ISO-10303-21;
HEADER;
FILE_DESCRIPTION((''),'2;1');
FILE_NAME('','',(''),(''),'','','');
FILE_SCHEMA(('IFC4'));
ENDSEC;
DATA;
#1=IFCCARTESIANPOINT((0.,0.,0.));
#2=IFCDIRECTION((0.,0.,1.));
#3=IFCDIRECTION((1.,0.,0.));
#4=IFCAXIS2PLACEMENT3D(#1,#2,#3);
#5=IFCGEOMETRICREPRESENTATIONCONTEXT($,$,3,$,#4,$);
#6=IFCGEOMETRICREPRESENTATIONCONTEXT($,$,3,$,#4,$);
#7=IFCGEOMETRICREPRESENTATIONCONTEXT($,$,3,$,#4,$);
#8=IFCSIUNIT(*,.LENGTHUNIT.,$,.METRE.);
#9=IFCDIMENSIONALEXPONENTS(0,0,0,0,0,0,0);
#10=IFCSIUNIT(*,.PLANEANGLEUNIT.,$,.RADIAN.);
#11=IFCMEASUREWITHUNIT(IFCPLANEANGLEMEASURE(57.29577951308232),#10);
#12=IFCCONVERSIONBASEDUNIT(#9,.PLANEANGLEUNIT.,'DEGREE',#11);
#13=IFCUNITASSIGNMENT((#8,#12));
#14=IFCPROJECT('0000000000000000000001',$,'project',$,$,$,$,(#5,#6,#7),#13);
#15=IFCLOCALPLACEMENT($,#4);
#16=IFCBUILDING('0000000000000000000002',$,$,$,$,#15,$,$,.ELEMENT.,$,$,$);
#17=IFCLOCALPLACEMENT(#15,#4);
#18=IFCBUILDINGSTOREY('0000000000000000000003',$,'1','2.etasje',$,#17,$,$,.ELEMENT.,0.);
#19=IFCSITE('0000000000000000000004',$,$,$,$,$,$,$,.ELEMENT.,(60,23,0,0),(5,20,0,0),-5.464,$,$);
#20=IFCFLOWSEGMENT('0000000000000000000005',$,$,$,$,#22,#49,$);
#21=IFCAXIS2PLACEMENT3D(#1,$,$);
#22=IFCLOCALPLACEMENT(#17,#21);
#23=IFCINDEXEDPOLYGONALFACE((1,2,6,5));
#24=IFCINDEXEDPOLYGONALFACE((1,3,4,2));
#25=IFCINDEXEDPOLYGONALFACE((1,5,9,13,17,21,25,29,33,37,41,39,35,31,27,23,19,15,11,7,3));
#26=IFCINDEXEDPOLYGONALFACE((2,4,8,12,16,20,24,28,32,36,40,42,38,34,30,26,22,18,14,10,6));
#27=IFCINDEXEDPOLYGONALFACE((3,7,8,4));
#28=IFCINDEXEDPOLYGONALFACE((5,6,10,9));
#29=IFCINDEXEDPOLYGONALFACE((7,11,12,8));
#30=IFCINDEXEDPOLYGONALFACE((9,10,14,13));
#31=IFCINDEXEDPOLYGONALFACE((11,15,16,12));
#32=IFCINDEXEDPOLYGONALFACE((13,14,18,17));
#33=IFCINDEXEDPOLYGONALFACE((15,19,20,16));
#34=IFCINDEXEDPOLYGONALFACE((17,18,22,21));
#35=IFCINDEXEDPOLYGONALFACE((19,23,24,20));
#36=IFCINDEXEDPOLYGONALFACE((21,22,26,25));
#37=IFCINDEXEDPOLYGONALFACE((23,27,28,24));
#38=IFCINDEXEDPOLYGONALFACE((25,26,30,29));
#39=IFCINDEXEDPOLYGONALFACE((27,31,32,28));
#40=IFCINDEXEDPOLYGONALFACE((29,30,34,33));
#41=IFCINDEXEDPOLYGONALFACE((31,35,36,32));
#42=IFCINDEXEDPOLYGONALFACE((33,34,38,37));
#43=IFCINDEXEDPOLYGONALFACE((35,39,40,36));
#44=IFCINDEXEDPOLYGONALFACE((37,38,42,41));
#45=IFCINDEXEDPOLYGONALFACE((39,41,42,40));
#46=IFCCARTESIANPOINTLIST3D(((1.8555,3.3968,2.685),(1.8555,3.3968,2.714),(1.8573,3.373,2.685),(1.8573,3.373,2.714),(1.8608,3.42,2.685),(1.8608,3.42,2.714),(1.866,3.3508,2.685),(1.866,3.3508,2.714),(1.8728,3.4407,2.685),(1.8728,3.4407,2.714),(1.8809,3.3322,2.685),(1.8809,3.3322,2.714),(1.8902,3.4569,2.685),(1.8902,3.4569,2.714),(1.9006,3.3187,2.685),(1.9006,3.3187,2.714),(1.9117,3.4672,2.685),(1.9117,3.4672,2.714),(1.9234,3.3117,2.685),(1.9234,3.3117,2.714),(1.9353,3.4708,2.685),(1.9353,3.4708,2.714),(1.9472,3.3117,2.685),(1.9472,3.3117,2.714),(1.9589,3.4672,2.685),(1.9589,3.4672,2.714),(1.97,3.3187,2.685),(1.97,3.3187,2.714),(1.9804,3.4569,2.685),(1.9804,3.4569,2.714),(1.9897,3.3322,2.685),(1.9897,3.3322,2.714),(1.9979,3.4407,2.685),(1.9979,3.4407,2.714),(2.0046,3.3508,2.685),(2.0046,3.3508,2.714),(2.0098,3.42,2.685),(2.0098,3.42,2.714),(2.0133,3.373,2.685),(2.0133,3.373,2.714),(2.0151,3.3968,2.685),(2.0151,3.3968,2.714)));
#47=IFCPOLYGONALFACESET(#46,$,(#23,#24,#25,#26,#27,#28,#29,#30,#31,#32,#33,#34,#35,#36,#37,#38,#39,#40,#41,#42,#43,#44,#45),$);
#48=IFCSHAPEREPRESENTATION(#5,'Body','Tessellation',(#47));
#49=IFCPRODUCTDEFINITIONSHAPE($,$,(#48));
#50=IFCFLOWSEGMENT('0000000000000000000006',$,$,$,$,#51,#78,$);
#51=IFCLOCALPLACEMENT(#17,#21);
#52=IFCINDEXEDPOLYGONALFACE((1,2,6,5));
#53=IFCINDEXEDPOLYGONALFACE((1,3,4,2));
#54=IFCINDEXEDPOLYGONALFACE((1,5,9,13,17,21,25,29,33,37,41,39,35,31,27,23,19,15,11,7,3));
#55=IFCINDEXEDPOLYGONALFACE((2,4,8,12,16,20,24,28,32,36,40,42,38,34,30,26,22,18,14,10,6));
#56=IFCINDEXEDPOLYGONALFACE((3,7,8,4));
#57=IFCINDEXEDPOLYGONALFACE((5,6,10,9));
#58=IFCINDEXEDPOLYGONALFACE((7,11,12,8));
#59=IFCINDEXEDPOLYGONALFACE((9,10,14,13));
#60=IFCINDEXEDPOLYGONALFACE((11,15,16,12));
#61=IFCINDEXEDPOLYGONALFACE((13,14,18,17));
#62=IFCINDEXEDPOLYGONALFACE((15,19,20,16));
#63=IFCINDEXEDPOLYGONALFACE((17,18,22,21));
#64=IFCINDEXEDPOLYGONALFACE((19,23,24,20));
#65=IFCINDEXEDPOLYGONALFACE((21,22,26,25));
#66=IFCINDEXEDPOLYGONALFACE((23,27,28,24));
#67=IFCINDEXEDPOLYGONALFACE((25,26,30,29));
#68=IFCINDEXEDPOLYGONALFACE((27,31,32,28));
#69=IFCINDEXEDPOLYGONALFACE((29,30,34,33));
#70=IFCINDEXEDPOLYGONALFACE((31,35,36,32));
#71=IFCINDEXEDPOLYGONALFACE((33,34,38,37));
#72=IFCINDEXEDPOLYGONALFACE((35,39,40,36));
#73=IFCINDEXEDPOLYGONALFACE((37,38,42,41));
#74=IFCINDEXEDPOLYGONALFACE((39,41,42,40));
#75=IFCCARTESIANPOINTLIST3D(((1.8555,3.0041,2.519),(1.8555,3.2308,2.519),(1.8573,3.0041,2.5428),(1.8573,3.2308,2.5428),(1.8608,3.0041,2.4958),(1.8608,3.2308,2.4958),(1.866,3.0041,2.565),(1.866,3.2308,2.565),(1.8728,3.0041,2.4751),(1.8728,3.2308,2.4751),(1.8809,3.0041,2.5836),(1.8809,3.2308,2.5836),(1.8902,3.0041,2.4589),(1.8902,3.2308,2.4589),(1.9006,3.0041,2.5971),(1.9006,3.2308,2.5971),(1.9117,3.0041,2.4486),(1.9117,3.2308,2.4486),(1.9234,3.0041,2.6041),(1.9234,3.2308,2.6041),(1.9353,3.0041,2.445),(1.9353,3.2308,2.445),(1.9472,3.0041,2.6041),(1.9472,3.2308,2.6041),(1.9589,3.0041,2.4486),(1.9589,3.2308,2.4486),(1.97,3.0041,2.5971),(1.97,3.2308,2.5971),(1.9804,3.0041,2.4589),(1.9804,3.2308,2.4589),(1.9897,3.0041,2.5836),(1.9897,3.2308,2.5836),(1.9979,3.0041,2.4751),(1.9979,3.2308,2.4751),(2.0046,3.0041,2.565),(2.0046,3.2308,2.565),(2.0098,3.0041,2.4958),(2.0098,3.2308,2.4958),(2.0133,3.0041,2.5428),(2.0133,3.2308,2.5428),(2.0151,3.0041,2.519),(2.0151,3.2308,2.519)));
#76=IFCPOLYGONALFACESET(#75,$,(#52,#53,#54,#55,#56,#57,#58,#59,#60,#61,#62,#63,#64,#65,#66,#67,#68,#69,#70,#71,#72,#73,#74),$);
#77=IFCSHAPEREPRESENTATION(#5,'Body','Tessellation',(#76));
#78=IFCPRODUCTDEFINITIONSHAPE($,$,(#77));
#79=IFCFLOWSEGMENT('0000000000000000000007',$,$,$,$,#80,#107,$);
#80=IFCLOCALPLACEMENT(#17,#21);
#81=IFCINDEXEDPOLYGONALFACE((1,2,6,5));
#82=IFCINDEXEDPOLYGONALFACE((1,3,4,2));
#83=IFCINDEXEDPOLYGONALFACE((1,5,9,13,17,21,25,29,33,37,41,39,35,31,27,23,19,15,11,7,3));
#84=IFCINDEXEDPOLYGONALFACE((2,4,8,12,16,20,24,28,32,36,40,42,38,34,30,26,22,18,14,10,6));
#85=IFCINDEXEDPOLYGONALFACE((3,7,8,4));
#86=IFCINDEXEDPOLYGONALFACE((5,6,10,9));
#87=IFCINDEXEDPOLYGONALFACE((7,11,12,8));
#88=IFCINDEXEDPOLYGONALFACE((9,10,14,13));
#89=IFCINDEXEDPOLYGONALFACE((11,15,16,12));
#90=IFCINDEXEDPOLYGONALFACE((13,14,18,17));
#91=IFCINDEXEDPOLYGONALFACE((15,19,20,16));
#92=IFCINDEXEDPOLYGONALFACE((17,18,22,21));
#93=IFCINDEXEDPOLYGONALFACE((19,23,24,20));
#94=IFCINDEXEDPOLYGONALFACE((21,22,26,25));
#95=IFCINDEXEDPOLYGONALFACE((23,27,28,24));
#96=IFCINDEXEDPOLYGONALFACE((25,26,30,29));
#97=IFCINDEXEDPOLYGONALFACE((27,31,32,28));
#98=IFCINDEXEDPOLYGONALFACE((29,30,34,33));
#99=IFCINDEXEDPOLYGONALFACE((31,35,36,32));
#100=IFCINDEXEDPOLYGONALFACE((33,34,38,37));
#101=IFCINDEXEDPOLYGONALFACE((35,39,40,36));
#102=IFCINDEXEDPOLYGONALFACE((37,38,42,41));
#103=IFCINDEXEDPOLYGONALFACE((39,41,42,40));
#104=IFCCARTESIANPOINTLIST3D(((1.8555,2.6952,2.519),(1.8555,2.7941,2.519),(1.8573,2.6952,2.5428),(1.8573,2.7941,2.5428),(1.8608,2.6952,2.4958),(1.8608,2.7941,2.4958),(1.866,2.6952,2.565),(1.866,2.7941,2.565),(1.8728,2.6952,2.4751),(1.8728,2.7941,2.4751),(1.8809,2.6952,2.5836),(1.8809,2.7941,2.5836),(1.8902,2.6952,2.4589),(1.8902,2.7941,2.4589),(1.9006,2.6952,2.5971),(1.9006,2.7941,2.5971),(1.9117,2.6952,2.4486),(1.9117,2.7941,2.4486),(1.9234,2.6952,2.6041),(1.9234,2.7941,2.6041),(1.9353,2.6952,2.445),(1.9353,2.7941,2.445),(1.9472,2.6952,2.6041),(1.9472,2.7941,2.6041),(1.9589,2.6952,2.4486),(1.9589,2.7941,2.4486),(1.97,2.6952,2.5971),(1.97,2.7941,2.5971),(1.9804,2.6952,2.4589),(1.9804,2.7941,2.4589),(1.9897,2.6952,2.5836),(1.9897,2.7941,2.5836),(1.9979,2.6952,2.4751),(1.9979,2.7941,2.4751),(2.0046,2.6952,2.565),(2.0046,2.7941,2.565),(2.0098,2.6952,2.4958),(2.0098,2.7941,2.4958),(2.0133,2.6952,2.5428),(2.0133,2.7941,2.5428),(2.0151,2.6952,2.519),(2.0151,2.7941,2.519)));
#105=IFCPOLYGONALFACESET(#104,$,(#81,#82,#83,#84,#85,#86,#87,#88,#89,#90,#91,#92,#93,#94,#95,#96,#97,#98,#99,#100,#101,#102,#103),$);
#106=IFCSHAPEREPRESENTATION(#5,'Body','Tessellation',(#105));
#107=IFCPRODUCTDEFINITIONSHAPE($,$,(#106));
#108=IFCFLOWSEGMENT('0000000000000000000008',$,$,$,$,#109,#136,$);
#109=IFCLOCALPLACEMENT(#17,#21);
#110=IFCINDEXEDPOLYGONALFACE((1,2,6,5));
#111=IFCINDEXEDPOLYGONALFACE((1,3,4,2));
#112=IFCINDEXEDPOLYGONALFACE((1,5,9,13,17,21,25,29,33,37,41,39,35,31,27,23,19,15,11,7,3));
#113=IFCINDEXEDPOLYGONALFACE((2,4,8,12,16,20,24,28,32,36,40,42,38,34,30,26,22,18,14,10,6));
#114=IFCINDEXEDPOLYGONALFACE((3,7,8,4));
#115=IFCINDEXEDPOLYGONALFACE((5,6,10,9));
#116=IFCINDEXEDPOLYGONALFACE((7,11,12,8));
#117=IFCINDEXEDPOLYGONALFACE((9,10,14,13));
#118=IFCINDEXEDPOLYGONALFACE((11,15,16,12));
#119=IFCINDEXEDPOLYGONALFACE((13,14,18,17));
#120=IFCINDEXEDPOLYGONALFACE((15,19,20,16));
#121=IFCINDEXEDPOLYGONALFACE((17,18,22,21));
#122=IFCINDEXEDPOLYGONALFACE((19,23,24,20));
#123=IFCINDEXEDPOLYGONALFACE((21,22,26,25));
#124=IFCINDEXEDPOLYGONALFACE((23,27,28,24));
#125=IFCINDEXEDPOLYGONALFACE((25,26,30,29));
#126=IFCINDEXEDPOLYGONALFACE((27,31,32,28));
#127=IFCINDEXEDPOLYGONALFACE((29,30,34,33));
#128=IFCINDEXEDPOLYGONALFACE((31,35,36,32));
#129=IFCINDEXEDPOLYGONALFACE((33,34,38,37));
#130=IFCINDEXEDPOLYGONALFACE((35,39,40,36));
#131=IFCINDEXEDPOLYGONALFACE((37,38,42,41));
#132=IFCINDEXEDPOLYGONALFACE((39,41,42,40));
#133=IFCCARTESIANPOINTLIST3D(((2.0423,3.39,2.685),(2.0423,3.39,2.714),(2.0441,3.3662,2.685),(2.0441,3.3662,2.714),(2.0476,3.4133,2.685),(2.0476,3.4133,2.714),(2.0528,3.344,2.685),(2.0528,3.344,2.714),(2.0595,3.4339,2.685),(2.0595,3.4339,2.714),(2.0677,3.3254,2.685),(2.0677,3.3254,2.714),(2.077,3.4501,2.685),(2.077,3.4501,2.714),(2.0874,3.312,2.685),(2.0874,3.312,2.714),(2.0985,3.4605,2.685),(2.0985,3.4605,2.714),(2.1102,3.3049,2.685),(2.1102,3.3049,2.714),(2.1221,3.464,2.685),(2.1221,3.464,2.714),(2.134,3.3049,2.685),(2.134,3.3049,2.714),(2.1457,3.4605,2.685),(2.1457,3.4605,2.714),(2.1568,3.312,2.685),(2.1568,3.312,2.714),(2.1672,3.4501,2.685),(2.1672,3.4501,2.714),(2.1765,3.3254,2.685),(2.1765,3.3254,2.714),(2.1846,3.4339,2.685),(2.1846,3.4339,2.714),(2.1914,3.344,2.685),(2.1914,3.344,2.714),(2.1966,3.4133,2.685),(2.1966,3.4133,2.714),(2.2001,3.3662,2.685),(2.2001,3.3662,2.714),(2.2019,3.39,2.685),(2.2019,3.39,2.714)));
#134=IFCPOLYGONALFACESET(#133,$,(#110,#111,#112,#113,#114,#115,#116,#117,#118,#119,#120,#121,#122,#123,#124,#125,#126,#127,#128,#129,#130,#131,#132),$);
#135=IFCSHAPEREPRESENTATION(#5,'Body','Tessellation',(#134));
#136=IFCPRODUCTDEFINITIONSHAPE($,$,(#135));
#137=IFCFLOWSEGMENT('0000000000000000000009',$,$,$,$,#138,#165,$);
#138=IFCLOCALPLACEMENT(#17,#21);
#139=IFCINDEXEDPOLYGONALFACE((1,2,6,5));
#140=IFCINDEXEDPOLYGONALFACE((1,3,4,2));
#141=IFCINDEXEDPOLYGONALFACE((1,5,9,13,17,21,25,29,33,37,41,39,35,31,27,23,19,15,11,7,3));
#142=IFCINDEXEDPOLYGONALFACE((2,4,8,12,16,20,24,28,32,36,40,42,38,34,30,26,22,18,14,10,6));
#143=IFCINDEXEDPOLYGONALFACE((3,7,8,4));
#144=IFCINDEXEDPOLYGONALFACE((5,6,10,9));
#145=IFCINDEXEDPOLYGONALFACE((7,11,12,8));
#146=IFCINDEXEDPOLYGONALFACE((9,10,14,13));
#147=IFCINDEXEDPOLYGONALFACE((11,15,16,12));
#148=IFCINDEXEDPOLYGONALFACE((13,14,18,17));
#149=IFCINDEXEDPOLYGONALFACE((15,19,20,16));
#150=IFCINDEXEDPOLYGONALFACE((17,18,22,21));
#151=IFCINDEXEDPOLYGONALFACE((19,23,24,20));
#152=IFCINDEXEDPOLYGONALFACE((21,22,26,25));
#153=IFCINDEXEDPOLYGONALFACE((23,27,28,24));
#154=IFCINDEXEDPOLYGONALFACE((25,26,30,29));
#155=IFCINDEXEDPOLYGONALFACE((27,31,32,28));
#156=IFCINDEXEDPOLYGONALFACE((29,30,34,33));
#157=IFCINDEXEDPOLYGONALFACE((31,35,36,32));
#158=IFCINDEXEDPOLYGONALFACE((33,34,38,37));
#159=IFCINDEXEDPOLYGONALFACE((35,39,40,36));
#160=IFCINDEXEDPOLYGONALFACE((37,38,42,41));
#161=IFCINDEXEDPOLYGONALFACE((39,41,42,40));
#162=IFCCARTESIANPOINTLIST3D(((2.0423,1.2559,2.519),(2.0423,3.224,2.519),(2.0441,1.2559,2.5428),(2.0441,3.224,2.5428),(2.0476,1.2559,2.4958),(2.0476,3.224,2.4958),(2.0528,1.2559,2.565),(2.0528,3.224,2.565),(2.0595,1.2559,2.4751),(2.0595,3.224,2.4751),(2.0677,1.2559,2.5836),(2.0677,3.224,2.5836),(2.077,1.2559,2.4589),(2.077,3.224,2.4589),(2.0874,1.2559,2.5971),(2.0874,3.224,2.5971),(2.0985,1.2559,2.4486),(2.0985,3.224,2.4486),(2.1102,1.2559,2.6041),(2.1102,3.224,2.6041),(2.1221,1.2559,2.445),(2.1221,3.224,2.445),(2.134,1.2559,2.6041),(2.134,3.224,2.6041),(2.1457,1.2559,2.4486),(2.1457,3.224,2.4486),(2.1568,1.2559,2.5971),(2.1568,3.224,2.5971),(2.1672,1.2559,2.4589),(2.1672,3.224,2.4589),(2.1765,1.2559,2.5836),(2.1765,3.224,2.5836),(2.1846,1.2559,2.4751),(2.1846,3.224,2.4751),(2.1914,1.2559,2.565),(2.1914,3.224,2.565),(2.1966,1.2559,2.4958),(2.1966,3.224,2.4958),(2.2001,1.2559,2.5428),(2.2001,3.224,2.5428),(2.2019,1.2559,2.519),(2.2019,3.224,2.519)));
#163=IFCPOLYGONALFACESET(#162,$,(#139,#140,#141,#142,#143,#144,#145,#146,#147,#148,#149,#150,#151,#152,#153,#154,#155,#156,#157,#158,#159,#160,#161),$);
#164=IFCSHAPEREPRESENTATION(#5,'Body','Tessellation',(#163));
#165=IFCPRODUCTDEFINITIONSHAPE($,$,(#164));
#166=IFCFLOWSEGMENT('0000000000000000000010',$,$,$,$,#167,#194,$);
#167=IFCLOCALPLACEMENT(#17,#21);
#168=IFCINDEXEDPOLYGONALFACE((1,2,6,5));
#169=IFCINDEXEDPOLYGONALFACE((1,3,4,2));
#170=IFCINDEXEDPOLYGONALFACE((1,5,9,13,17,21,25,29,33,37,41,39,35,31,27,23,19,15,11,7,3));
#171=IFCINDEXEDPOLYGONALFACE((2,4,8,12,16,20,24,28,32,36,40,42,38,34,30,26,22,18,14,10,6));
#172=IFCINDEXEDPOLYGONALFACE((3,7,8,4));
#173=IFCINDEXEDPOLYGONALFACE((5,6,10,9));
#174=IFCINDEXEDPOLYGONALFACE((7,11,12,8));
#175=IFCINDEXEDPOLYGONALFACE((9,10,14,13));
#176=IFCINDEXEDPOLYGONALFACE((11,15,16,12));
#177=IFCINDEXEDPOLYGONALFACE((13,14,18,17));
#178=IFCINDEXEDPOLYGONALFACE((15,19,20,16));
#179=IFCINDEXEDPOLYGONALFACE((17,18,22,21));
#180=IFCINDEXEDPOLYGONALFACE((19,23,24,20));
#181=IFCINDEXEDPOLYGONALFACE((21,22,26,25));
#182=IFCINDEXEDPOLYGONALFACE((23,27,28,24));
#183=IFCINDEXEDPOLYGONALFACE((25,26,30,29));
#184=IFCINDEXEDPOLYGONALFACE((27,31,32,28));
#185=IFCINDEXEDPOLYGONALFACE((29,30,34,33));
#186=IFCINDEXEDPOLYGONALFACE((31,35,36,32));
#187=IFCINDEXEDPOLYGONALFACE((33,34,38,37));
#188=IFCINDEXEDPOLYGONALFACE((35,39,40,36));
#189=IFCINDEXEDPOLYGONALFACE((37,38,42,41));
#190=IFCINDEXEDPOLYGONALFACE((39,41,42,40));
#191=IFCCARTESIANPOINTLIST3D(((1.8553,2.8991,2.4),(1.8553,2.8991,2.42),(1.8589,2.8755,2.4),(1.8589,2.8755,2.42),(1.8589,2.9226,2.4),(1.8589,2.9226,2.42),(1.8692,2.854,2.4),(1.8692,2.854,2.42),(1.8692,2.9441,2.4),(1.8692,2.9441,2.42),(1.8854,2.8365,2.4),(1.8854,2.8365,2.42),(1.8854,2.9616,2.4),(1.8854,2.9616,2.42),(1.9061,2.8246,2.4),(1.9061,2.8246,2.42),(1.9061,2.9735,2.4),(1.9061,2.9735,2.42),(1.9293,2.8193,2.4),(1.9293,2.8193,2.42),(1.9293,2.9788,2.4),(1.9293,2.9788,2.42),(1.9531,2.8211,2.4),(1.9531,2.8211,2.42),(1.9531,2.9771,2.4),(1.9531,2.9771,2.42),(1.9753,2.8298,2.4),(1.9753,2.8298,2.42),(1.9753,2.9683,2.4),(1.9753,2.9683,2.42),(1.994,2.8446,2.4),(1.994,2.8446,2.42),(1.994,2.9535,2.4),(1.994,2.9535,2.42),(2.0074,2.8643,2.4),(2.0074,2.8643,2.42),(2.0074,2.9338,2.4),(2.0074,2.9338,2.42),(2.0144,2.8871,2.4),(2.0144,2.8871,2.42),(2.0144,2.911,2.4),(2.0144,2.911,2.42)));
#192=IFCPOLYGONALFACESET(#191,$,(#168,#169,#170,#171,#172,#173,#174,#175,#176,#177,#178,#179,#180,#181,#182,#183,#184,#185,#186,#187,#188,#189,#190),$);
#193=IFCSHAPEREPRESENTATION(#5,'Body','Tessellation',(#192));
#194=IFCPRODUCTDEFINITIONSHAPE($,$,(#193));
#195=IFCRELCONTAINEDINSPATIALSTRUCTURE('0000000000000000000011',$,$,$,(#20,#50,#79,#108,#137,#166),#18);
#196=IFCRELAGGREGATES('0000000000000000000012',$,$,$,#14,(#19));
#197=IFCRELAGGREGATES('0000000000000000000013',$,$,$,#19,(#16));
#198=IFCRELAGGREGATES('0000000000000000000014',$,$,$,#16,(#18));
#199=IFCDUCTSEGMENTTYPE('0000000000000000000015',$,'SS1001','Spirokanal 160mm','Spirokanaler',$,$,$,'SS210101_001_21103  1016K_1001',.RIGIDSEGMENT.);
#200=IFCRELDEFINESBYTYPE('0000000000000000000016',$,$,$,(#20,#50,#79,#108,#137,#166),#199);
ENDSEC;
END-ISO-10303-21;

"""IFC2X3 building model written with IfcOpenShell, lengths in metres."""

from ifc_helpers import new_model, entity, si_unit, converted_unit, frame, origin_with_axes, origin_2d_with_axis, place, context, project, spatial, circle, extrude, type_object, element, save


model = new_model("IFC2X3")

# Units and contexts
context_of_model_1 = context(None, 3, world=origin_with_axes())
context_of_model_2 = context(None, 3, world=origin_with_axes())
context_of_model_3 = context(None, 3, world=origin_with_axes())
ifc_project = project(units=[si_unit("LENGTHUNIT", "METRE"), converted_unit("PLANEANGLEUNIT", "DEGREE", entity("IfcPlaneAngleMeasure", 57.29577951308232), si_unit("PLANEANGLEUNIT", "RADIAN"), dimensions=[0, 0, 0, 0, 0, 0, 0])], contexts=[context_of_model_1, context_of_model_2, context_of_model_3])

# Site, building, storey
site = spatial("IfcSite", under=ifc_project, CompositionType="ELEMENT", RefLatitude=(60, 23, 0, 0), RefLongitude=(5, 20, 0, 0), RefElevation=-5.464)
building_placement = place(None, origin_with_axes())
building = spatial("IfcBuilding", under=site, at=building_placement, CompositionType="ELEMENT")
storey_placement = place(building_placement, origin_with_axes())
storey = spatial("IfcBuildingStorey", under=building, at=storey_placement, Name="1", Description="2.etasje", CompositionType="ELEMENT", Elevation=0.0)

# Flow segments
duct_segment_type_1 = type_object("IfcDuctSegmentType", Name="SS1001", Description="Spirokanal 160mm", ApplicableOccurrence="Spirokanaler", ElementType="SS210101_001_21103  1016K_1001", PredefinedType="RIGIDSEGMENT")
flow_segment_1_placement = place(storey_placement, frame((1.9353, 3.3908, 2.714), z_axis=(0.0, 0.0, -1.0), x_axis=(0.0, 1.0, 0.0)))
element("IfcFlowSegment", 1, at=flow_segment_1_placement, inside=storey, type_object=duct_segment_type_1, context=context_of_model_1, shape_type="SweptSolid", body=[
    extrude(circle(Radius=0.08, at=origin_2d_with_axis()), origin_with_axes(), (0.0, 0.0, 1.0), 0.029),
])
flow_segment_2_placement = place(storey_placement, frame((1.9353, 3.2308, 2.525), z_axis=(0.0, -1.0, 0.0), x_axis=(0.0, 0.0, -1.0)))
element("IfcFlowSegment", 2, at=flow_segment_2_placement, inside=storey, type_object=duct_segment_type_1, context=context_of_model_1, shape_type="SweptSolid", body=[
    extrude(circle(Radius=0.08, at=origin_2d_with_axis()), origin_with_axes(), (0.0, 0.0, 1.0), 0.2267),
])
flow_segment_3_placement = place(storey_placement, frame((1.9353, 2.7941, 2.525), z_axis=(0.0, -1.0, 0.0), x_axis=(0.0, 0.0, -1.0)))
element("IfcFlowSegment", 3, at=flow_segment_3_placement, inside=storey, type_object=duct_segment_type_1, context=context_of_model_1, shape_type="SweptSolid", body=[
    extrude(circle(Radius=0.08, at=origin_2d_with_axis()), origin_with_axes(), (0.0, 0.0, 1.0), 0.0988),
])
flow_segment_4_placement = place(storey_placement, frame((2.1221, 3.384, 2.714), z_axis=(0.0, 0.0, -1.0), x_axis=(0.0, 1.0, 0.0)))
element("IfcFlowSegment", 4, at=flow_segment_4_placement, inside=storey, type_object=duct_segment_type_1, context=context_of_model_1, shape_type="SweptSolid", body=[
    extrude(circle(Radius=0.08, at=origin_2d_with_axis()), origin_with_axes(), (0.0, 0.0, 1.0), 0.029),
])
flow_segment_5_placement = place(storey_placement, frame((2.1221, 3.224, 2.525), z_axis=(0.0, -1.0, 0.0), x_axis=(0.0, 0.0, -1.0)))
element("IfcFlowSegment", 5, at=flow_segment_5_placement, inside=storey, type_object=duct_segment_type_1, context=context_of_model_1, shape_type="SweptSolid", body=[
    extrude(circle(Radius=0.08, at=origin_2d_with_axis()), origin_with_axes(), (0.0, 0.0, 1.0), 1.9681),
])
flow_segment_6_placement = place(storey_placement, frame((1.9353, 2.8991, 2.42), z_axis=(0.0, 0.0, -1.0), x_axis=(-1.0, 0.0, 0.0)))
element("IfcFlowSegment", 6, at=flow_segment_6_placement, inside=storey, type_object=duct_segment_type_1, context=context_of_model_1, shape_type="SweptSolid", body=[
    extrude(circle(Radius=0.08, at=origin_2d_with_axis()), origin_with_axes(), (0.0, 0.0, 1.0), 0.02),
])

save(model, "model.ifc")
